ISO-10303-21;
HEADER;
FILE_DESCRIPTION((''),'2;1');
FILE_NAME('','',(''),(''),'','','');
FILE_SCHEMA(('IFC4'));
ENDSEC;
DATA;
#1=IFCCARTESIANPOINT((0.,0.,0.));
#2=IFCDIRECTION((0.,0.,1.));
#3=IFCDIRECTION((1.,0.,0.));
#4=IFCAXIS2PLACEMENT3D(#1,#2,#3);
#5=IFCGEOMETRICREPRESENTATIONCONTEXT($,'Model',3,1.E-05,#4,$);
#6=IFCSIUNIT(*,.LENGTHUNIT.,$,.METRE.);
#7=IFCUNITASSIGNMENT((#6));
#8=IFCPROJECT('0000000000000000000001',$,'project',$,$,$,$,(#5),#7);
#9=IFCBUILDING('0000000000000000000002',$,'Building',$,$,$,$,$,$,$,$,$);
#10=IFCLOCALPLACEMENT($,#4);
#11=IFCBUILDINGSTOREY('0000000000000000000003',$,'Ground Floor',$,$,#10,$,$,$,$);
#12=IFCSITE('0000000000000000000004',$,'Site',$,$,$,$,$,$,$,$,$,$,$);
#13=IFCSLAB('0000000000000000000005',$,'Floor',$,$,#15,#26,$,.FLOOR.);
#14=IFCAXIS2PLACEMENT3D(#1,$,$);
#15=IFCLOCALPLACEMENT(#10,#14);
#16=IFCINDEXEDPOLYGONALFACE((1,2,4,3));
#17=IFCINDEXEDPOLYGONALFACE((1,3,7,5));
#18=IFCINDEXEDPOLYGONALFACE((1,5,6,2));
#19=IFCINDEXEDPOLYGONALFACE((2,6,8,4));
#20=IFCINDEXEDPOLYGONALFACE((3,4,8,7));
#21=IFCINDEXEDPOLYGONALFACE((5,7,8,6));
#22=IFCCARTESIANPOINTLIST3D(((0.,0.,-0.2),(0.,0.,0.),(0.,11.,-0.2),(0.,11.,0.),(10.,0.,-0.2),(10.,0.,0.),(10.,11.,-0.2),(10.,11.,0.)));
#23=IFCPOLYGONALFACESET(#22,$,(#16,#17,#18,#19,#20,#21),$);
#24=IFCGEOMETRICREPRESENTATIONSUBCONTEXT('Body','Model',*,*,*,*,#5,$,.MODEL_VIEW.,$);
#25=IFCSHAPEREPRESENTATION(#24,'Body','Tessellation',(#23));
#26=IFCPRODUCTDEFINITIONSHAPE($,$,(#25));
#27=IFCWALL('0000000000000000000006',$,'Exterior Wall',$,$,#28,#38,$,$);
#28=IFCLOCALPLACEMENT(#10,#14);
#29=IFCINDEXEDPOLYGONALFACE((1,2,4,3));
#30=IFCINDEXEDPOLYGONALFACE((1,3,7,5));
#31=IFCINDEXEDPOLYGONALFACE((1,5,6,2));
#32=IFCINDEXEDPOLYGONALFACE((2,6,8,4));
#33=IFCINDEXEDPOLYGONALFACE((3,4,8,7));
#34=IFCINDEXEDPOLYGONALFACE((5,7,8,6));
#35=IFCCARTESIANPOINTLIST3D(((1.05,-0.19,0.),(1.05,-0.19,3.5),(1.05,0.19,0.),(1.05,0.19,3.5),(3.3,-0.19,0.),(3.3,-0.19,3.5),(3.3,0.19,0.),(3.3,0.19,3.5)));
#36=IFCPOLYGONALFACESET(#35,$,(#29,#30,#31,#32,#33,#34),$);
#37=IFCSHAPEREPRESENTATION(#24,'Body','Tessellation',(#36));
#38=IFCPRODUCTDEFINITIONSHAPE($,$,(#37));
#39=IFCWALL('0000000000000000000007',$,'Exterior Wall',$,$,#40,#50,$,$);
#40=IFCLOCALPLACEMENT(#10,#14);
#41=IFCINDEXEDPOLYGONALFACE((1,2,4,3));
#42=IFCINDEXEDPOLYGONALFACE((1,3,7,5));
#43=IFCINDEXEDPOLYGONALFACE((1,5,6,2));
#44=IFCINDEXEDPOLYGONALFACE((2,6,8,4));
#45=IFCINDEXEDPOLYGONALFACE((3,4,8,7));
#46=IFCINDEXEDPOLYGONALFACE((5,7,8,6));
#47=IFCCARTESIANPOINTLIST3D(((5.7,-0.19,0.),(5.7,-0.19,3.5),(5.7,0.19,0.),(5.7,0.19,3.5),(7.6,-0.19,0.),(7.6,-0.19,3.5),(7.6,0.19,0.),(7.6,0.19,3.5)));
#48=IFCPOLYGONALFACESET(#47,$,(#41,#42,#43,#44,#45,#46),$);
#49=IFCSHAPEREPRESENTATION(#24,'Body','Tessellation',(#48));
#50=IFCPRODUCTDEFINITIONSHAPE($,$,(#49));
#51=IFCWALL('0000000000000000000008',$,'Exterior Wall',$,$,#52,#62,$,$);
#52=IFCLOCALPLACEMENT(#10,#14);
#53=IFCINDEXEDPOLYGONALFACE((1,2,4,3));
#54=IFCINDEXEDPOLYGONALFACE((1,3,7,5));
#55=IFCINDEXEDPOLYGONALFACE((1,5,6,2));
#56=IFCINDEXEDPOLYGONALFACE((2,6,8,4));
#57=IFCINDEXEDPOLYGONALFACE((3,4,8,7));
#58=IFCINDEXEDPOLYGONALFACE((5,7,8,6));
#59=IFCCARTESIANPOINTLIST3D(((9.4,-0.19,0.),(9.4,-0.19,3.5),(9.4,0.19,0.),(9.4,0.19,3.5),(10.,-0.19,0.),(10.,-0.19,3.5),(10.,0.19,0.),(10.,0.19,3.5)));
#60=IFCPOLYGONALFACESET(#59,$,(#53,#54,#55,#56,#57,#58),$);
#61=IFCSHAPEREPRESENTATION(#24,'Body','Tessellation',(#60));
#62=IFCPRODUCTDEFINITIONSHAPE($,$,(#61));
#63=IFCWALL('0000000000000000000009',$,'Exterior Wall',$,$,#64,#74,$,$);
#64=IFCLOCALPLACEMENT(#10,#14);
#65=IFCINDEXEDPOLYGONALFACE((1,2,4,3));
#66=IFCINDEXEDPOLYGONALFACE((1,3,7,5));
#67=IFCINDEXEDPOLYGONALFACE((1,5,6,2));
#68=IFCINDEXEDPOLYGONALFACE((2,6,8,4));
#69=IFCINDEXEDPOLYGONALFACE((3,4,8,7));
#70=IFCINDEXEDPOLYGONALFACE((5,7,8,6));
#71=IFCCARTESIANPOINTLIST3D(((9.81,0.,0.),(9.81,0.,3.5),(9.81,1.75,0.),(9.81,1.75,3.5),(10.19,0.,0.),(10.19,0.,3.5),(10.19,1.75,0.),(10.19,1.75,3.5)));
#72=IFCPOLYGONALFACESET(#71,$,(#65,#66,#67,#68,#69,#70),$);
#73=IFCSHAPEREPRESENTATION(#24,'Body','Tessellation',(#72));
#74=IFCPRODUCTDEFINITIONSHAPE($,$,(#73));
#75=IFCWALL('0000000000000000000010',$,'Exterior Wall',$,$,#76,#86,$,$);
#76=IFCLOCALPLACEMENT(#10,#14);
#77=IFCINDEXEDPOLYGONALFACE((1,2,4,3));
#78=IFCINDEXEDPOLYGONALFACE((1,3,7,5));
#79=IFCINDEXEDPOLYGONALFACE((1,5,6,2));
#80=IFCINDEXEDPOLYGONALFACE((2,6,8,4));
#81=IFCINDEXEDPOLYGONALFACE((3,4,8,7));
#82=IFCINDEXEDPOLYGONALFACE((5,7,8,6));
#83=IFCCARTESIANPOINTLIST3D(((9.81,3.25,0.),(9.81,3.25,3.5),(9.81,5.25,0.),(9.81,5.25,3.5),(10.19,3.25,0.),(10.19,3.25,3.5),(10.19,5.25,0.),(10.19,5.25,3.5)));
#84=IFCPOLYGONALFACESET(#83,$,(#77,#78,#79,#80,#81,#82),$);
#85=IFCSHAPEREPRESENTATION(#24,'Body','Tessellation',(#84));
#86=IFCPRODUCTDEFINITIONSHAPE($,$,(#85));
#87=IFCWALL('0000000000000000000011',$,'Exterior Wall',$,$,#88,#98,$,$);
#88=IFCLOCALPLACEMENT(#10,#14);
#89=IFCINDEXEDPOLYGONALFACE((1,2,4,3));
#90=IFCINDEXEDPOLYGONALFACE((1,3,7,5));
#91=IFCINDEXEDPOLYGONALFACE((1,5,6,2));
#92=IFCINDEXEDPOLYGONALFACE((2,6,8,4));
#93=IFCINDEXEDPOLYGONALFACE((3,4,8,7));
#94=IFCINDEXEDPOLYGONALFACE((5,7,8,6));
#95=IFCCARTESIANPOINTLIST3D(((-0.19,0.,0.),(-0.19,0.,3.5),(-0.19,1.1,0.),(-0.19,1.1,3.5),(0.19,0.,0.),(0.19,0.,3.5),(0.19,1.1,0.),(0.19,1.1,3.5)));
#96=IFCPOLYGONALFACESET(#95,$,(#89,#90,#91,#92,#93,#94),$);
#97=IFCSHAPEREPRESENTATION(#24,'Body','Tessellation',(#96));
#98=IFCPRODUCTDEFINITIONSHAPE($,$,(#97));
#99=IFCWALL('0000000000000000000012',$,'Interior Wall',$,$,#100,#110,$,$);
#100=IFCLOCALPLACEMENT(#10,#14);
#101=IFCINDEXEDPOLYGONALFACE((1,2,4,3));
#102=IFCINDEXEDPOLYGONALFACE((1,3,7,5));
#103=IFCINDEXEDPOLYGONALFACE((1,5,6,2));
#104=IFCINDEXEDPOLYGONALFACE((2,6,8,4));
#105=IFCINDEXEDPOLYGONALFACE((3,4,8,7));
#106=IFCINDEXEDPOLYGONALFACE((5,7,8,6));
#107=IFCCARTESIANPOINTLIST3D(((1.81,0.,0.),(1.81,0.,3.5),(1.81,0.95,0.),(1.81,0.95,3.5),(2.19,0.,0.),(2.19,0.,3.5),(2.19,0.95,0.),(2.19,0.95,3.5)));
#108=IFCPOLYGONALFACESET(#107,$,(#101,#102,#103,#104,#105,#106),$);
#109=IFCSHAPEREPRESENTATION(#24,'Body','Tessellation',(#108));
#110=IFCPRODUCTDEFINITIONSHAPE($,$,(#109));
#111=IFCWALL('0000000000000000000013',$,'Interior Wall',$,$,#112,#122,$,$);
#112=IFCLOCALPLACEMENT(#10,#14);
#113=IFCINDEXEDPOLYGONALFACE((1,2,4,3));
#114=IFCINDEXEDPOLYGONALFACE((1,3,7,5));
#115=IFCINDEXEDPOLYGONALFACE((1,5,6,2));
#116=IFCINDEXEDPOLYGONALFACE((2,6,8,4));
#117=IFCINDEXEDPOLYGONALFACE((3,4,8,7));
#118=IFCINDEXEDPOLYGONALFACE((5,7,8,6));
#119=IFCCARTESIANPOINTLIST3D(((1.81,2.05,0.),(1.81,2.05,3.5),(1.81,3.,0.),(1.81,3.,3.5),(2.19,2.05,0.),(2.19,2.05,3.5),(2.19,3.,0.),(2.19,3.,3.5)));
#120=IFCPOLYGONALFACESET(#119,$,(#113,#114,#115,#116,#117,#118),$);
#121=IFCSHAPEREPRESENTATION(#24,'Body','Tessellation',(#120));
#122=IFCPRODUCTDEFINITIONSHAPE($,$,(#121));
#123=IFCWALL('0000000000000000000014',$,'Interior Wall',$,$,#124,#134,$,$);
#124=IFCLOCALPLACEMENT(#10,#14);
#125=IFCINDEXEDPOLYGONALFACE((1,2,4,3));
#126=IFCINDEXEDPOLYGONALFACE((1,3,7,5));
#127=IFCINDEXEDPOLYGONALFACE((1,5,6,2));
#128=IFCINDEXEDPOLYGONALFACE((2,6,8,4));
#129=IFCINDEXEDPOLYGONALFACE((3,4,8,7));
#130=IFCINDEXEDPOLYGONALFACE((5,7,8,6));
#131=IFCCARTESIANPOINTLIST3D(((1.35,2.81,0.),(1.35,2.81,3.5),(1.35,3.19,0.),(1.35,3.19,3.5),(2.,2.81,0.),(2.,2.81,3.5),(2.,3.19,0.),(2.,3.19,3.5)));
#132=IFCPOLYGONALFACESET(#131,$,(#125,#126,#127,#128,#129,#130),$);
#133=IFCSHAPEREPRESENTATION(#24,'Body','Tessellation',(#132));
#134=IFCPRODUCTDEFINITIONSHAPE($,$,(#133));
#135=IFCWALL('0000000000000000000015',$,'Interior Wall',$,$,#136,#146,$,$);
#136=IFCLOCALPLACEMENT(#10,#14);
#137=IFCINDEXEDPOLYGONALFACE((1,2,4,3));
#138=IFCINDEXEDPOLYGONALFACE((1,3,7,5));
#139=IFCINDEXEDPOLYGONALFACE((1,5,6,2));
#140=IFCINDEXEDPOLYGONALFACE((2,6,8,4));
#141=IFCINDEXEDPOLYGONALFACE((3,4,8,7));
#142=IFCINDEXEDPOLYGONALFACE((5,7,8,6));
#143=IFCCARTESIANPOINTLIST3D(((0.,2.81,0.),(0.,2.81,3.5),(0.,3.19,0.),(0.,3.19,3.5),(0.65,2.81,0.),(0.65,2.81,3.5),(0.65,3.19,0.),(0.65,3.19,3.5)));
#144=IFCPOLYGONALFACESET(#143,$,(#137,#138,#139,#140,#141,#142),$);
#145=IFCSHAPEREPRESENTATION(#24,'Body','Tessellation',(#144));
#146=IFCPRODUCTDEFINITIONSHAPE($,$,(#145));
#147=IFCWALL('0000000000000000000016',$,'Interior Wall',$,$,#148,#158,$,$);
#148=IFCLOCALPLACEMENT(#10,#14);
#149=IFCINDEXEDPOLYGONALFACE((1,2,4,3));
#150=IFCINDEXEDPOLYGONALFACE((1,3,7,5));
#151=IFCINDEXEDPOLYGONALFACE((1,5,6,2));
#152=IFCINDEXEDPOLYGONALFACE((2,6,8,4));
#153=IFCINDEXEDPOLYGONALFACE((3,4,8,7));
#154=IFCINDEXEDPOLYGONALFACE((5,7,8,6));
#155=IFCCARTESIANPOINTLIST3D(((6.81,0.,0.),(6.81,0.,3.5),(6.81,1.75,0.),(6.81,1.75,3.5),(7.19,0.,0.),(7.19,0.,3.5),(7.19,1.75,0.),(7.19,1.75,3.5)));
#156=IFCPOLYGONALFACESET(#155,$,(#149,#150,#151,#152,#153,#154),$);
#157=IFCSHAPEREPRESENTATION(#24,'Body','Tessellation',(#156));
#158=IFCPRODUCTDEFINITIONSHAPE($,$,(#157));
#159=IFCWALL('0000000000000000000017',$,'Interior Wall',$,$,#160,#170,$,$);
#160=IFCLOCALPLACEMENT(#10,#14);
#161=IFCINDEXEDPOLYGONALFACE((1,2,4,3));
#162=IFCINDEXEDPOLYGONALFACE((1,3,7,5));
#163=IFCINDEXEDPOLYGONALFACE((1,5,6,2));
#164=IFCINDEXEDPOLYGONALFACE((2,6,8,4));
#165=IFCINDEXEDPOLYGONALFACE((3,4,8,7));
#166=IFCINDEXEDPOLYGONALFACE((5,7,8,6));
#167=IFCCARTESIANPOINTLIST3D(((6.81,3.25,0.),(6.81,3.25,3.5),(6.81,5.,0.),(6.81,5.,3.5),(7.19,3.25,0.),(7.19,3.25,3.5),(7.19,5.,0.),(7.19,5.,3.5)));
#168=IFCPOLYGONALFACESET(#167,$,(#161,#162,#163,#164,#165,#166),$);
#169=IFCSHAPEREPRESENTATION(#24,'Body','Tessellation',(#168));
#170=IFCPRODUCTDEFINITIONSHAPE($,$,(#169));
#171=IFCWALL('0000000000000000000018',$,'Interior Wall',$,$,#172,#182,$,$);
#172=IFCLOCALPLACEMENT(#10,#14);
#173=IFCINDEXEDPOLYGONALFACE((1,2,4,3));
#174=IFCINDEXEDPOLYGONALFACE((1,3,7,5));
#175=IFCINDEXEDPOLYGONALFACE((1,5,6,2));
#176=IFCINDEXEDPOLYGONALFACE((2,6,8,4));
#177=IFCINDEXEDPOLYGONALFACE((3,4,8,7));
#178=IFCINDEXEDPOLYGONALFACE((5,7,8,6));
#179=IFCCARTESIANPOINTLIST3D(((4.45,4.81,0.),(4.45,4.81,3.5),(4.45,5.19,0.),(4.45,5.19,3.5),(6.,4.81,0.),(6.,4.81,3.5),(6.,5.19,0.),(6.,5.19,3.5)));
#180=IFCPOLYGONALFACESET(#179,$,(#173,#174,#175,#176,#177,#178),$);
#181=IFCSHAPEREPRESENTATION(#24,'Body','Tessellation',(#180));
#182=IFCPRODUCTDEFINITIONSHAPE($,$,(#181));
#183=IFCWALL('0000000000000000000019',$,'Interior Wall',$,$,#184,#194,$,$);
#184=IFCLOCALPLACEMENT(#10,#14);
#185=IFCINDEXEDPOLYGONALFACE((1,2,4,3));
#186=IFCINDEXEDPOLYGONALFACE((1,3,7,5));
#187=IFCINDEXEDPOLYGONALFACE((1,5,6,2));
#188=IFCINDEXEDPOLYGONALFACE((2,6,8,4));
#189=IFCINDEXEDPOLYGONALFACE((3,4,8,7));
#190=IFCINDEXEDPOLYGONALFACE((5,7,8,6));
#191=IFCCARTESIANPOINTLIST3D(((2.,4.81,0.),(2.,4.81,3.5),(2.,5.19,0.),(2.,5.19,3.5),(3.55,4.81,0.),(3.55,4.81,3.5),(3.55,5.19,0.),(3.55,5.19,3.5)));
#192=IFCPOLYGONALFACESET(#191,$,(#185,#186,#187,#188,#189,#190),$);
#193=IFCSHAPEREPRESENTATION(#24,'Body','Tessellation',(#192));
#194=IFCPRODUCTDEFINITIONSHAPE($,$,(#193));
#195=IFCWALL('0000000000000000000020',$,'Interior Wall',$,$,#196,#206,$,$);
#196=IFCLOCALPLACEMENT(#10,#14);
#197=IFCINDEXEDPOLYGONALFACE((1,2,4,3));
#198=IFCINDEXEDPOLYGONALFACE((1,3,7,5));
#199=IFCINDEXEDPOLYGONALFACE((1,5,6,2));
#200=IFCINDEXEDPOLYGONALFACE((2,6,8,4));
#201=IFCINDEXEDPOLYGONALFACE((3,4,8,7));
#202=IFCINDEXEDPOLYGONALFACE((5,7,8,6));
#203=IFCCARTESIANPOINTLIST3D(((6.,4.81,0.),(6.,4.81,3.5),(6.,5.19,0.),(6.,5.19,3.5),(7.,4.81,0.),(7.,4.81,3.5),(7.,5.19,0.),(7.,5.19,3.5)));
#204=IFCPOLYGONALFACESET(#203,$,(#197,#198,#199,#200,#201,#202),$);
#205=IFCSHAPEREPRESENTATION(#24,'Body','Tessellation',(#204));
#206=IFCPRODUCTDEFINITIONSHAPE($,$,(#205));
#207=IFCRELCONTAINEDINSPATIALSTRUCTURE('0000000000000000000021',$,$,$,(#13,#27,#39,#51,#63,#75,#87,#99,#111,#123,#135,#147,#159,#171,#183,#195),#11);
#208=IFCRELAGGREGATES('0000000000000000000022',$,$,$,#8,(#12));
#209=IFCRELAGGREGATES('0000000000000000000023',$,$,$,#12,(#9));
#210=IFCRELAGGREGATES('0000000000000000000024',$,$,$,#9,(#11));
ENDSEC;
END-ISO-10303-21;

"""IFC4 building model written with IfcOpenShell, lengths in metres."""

from ifc_helpers import new_model, si_unit, frame, origin_with_axes, place, context, subcontext, project, spatial, indexed_curve, outline, extrude, element, save


model = new_model("IFC4")

# Units and contexts
model_context = context("Model", 3, precision=1e-05, world=origin_with_axes())
body_context = subcontext(model_context, "Body", "Model", "MODEL_VIEW")
ifc_project = project(units=[si_unit("LENGTHUNIT", "METRE")], contexts=[model_context])

# Site, building, storey
site = spatial("IfcSite", under=ifc_project, Name="Site")
building = spatial("IfcBuilding", under=site, Name="Building")
storey_placement = place(None, origin_with_axes())
storey = spatial("IfcBuildingStorey", under=building, at=storey_placement, Name="Ground Floor")

# Slab
slab_placement = place(storey_placement, frame((0.0, 0.0, -0.2), z_axis=(0.0, 0.0, 1.0), x_axis=(1.0, 0.0, 0.0)))
element("IfcSlab", 1, at=slab_placement, inside=storey, Name="Floor", PredefinedType="FLOOR", context=body_context, shape_type="SweptSolid", body=[
    extrude(outline(indexed_curve([(0.0, 0.0), (10.0, 0.0), (10.0, 11.0), (0.0, 11.0)])), None, (0.0, 0.0, 1.0), 0.2),
])

# Walls
wall_1_placement = place(storey_placement, frame((1.05, 0.0, 0.0), z_axis=(0.0, 0.0, 1.0), x_axis=(1.0, 0.0, 0.0)))
element("IfcWall", 2, at=wall_1_placement, inside=storey, Name="Exterior Wall", context=body_context, shape_type="SweptSolid", body=[
    extrude(outline(indexed_curve([(0.0, 0.0), (0.0, 0.38), (2.25, 0.38), (2.25, 0.0), (0.0, 0.0)], self_intersect=False)), frame((0.0, -0.19, 0.0), z_axis=(0.0, 0.0, 1.0), x_axis=(1.0, 0.0, 0.0)), (0.0, 0.0, 1.0), 3.5),
])
wall_2_placement = place(storey_placement, frame((5.7, 0.0, 0.0), z_axis=(0.0, 0.0, 1.0), x_axis=(1.0, 0.0, 0.0)))
element("IfcWall", 3, at=wall_2_placement, inside=storey, Name="Exterior Wall", context=body_context, shape_type="SweptSolid", body=[
    extrude(outline(indexed_curve([(0.0, 0.0), (0.0, 0.38), (1.9, 0.38), (1.9, 0.0), (0.0, 0.0)], self_intersect=False)), frame((0.0, -0.19, 0.0), z_axis=(0.0, 0.0, 1.0), x_axis=(1.0, 0.0, 0.0)), (0.0, 0.0, 1.0), 3.5),
])
wall_3_placement = place(storey_placement, frame((9.4, 0.0, 0.0), z_axis=(0.0, 0.0, 1.0), x_axis=(1.0, 0.0, 0.0)))
element("IfcWall", 4, at=wall_3_placement, inside=storey, Name="Exterior Wall", context=body_context, shape_type="SweptSolid", body=[
    extrude(outline(indexed_curve([(0.0, 0.0), (0.0, 0.38), (0.6, 0.38), (0.6, 0.0), (0.0, 0.0)], self_intersect=False)), frame((0.0, -0.19, 0.0), z_axis=(0.0, 0.0, 1.0), x_axis=(1.0, 0.0, 0.0)), (0.0, 0.0, 1.0), 3.5),
])
wall_4_placement = place(storey_placement, frame((10.0, 0.0, 0.0), z_axis=(0.0, 0.0, 1.0), x_axis=(0.0, 1.0, 0.0)))
element("IfcWall", 5, at=wall_4_placement, inside=storey, Name="Exterior Wall", context=body_context, shape_type="SweptSolid", body=[
    extrude(outline(indexed_curve([(0.0, 0.0), (0.0, 0.38), (1.75, 0.38), (1.75, 0.0), (0.0, 0.0)], self_intersect=False)), frame((0.0, -0.19, 0.0), z_axis=(0.0, 0.0, 1.0), x_axis=(1.0, 0.0, 0.0)), (0.0, 0.0, 1.0), 3.5),
])
wall_5_placement = place(storey_placement, frame((10.0, 3.25, 0.0), z_axis=(0.0, 0.0, 1.0), x_axis=(0.0, 1.0, 0.0)))
element("IfcWall", 6, at=wall_5_placement, inside=storey, Name="Exterior Wall", context=body_context, shape_type="SweptSolid", body=[
    extrude(outline(indexed_curve([(0.0, 0.0), (0.0, 0.38), (2.0, 0.38), (2.0, 0.0), (0.0, 0.0)], self_intersect=False)), frame((0.0, -0.19, 0.0), z_axis=(0.0, 0.0, 1.0), x_axis=(1.0, 0.0, 0.0)), (0.0, 0.0, 1.0), 3.5),
])
wall_6_placement = place(storey_placement, frame((0.0, 1.1, 0.0), z_axis=(0.0, 0.0, 1.0), x_axis=(0.0, -1.0, 0.0)))
element("IfcWall", 7, at=wall_6_placement, inside=storey, Name="Exterior Wall", context=body_context, shape_type="SweptSolid", body=[
    extrude(outline(indexed_curve([(0.0, 0.0), (0.0, 0.38), (1.1, 0.38), (1.1, 0.0), (0.0, 0.0)], self_intersect=False)), frame((0.0, -0.19, 0.0), z_axis=(0.0, 0.0, 1.0), x_axis=(1.0, 0.0, 0.0)), (0.0, 0.0, 1.0), 3.5),
])
wall_7_placement = place(storey_placement, frame((2.0, 0.0, 0.0), z_axis=(0.0, 0.0, 1.0), x_axis=(0.0, 1.0, 0.0)))
element("IfcWall", 8, at=wall_7_placement, inside=storey, Name="Interior Wall", context=body_context, shape_type="SweptSolid", body=[
    extrude(outline(indexed_curve([(0.0, 0.0), (0.0, 0.38), (0.95, 0.38), (0.95, 0.0), (0.0, 0.0)], self_intersect=False)), frame((0.0, -0.19, 0.0), z_axis=(0.0, 0.0, 1.0), x_axis=(1.0, 0.0, 0.0)), (0.0, 0.0, 1.0), 3.5),
])
wall_8_placement = place(storey_placement, frame((2.0, 2.05, 0.0), z_axis=(0.0, 0.0, 1.0), x_axis=(0.0, 1.0, 0.0)))
element("IfcWall", 9, at=wall_8_placement, inside=storey, Name="Interior Wall", context=body_context, shape_type="SweptSolid", body=[
    extrude(outline(indexed_curve([(0.0, 0.0), (0.0, 0.38), (0.95, 0.38), (0.95, 0.0), (0.0, 0.0)], self_intersect=False)), frame((0.0, -0.19, 0.0), z_axis=(0.0, 0.0, 1.0), x_axis=(1.0, 0.0, 0.0)), (0.0, 0.0, 1.0), 3.5),
])
for number, where, z_axis, x_axis, name in (
    (10, (2.0, 3.0, 0.0), (0.0, 0.0, 1.0), (-1.0, 0.0, 0.0), "Interior Wall"),
    (11, (0.65, 3.0, 0.0), (0.0, 0.0, 1.0), (-1.0, 0.0, 0.0), "Interior Wall"),
):
    element("IfcWall", number, at=place(storey_placement, frame(where, z_axis=z_axis, x_axis=x_axis)), inside=storey, Name=name, context=body_context, shape_type="SweptSolid", body=[
        extrude(outline(indexed_curve([(0.0, 0.0), (0.0, 0.38), (0.65, 0.38), (0.65, 0.0), (0.0, 0.0)], self_intersect=False)), frame((0.0, -0.19, 0.0), z_axis=(0.0, 0.0, 1.0), x_axis=(1.0, 0.0, 0.0)), (0.0, 0.0, 1.0), 3.5),
    ])
for number, where, z_axis, x_axis, name in (
    (12, (7.0, 0.0, 0.0), (0.0, 0.0, 1.0), (0.0, 1.0, 0.0), "Interior Wall"),
    (13, (7.0, 3.25, 0.0), (0.0, 0.0, 1.0), (0.0, 1.0, 0.0), "Interior Wall"),
):
    element("IfcWall", number, at=place(storey_placement, frame(where, z_axis=z_axis, x_axis=x_axis)), inside=storey, Name=name, context=body_context, shape_type="SweptSolid", body=[
        extrude(outline(indexed_curve([(0.0, 0.0), (0.0, 0.38), (1.75, 0.38), (1.75, 0.0), (0.0, 0.0)], self_intersect=False)), frame((0.0, -0.19, 0.0), z_axis=(0.0, 0.0, 1.0), x_axis=(1.0, 0.0, 0.0)), (0.0, 0.0, 1.0), 3.5),
    ])
for number, where, z_axis, x_axis, name in (
    (14, (6.0, 5.0, 0.0), (0.0, 0.0, 1.0), (-1.0, 0.0, 0.0), "Interior Wall"),
    (15, (3.55, 5.0, 0.0), (0.0, 0.0, 1.0), (-1.0, 0.0, 0.0), "Interior Wall"),
):
    element("IfcWall", number, at=place(storey_placement, frame(where, z_axis=z_axis, x_axis=x_axis)), inside=storey, Name=name, context=body_context, shape_type="SweptSolid", body=[
        extrude(outline(indexed_curve([(0.0, 0.0), (0.0, 0.38), (1.55, 0.38), (1.55, 0.0), (0.0, 0.0)], self_intersect=False)), frame((0.0, -0.19, 0.0), z_axis=(0.0, 0.0, 1.0), x_axis=(1.0, 0.0, 0.0)), (0.0, 0.0, 1.0), 3.5),
    ])
wall_9_placement = place(storey_placement, frame((7.0, 5.0, 0.0), z_axis=(0.0, 0.0, 1.0), x_axis=(-1.0, 0.0, 0.0)))
element("IfcWall", 16, at=wall_9_placement, inside=storey, Name="Interior Wall", context=body_context, shape_type="SweptSolid", body=[
    extrude(outline(indexed_curve([(0.0, 0.0), (0.0, 0.38), (1.0, 0.38), (1.0, 0.0), (0.0, 0.0)], self_intersect=False)), frame((0.0, -0.19, 0.0), z_axis=(0.0, 0.0, 1.0), x_axis=(1.0, 0.0, 0.0)), (0.0, 0.0, 1.0), 3.5),
])

save(model, "model.ifc")
